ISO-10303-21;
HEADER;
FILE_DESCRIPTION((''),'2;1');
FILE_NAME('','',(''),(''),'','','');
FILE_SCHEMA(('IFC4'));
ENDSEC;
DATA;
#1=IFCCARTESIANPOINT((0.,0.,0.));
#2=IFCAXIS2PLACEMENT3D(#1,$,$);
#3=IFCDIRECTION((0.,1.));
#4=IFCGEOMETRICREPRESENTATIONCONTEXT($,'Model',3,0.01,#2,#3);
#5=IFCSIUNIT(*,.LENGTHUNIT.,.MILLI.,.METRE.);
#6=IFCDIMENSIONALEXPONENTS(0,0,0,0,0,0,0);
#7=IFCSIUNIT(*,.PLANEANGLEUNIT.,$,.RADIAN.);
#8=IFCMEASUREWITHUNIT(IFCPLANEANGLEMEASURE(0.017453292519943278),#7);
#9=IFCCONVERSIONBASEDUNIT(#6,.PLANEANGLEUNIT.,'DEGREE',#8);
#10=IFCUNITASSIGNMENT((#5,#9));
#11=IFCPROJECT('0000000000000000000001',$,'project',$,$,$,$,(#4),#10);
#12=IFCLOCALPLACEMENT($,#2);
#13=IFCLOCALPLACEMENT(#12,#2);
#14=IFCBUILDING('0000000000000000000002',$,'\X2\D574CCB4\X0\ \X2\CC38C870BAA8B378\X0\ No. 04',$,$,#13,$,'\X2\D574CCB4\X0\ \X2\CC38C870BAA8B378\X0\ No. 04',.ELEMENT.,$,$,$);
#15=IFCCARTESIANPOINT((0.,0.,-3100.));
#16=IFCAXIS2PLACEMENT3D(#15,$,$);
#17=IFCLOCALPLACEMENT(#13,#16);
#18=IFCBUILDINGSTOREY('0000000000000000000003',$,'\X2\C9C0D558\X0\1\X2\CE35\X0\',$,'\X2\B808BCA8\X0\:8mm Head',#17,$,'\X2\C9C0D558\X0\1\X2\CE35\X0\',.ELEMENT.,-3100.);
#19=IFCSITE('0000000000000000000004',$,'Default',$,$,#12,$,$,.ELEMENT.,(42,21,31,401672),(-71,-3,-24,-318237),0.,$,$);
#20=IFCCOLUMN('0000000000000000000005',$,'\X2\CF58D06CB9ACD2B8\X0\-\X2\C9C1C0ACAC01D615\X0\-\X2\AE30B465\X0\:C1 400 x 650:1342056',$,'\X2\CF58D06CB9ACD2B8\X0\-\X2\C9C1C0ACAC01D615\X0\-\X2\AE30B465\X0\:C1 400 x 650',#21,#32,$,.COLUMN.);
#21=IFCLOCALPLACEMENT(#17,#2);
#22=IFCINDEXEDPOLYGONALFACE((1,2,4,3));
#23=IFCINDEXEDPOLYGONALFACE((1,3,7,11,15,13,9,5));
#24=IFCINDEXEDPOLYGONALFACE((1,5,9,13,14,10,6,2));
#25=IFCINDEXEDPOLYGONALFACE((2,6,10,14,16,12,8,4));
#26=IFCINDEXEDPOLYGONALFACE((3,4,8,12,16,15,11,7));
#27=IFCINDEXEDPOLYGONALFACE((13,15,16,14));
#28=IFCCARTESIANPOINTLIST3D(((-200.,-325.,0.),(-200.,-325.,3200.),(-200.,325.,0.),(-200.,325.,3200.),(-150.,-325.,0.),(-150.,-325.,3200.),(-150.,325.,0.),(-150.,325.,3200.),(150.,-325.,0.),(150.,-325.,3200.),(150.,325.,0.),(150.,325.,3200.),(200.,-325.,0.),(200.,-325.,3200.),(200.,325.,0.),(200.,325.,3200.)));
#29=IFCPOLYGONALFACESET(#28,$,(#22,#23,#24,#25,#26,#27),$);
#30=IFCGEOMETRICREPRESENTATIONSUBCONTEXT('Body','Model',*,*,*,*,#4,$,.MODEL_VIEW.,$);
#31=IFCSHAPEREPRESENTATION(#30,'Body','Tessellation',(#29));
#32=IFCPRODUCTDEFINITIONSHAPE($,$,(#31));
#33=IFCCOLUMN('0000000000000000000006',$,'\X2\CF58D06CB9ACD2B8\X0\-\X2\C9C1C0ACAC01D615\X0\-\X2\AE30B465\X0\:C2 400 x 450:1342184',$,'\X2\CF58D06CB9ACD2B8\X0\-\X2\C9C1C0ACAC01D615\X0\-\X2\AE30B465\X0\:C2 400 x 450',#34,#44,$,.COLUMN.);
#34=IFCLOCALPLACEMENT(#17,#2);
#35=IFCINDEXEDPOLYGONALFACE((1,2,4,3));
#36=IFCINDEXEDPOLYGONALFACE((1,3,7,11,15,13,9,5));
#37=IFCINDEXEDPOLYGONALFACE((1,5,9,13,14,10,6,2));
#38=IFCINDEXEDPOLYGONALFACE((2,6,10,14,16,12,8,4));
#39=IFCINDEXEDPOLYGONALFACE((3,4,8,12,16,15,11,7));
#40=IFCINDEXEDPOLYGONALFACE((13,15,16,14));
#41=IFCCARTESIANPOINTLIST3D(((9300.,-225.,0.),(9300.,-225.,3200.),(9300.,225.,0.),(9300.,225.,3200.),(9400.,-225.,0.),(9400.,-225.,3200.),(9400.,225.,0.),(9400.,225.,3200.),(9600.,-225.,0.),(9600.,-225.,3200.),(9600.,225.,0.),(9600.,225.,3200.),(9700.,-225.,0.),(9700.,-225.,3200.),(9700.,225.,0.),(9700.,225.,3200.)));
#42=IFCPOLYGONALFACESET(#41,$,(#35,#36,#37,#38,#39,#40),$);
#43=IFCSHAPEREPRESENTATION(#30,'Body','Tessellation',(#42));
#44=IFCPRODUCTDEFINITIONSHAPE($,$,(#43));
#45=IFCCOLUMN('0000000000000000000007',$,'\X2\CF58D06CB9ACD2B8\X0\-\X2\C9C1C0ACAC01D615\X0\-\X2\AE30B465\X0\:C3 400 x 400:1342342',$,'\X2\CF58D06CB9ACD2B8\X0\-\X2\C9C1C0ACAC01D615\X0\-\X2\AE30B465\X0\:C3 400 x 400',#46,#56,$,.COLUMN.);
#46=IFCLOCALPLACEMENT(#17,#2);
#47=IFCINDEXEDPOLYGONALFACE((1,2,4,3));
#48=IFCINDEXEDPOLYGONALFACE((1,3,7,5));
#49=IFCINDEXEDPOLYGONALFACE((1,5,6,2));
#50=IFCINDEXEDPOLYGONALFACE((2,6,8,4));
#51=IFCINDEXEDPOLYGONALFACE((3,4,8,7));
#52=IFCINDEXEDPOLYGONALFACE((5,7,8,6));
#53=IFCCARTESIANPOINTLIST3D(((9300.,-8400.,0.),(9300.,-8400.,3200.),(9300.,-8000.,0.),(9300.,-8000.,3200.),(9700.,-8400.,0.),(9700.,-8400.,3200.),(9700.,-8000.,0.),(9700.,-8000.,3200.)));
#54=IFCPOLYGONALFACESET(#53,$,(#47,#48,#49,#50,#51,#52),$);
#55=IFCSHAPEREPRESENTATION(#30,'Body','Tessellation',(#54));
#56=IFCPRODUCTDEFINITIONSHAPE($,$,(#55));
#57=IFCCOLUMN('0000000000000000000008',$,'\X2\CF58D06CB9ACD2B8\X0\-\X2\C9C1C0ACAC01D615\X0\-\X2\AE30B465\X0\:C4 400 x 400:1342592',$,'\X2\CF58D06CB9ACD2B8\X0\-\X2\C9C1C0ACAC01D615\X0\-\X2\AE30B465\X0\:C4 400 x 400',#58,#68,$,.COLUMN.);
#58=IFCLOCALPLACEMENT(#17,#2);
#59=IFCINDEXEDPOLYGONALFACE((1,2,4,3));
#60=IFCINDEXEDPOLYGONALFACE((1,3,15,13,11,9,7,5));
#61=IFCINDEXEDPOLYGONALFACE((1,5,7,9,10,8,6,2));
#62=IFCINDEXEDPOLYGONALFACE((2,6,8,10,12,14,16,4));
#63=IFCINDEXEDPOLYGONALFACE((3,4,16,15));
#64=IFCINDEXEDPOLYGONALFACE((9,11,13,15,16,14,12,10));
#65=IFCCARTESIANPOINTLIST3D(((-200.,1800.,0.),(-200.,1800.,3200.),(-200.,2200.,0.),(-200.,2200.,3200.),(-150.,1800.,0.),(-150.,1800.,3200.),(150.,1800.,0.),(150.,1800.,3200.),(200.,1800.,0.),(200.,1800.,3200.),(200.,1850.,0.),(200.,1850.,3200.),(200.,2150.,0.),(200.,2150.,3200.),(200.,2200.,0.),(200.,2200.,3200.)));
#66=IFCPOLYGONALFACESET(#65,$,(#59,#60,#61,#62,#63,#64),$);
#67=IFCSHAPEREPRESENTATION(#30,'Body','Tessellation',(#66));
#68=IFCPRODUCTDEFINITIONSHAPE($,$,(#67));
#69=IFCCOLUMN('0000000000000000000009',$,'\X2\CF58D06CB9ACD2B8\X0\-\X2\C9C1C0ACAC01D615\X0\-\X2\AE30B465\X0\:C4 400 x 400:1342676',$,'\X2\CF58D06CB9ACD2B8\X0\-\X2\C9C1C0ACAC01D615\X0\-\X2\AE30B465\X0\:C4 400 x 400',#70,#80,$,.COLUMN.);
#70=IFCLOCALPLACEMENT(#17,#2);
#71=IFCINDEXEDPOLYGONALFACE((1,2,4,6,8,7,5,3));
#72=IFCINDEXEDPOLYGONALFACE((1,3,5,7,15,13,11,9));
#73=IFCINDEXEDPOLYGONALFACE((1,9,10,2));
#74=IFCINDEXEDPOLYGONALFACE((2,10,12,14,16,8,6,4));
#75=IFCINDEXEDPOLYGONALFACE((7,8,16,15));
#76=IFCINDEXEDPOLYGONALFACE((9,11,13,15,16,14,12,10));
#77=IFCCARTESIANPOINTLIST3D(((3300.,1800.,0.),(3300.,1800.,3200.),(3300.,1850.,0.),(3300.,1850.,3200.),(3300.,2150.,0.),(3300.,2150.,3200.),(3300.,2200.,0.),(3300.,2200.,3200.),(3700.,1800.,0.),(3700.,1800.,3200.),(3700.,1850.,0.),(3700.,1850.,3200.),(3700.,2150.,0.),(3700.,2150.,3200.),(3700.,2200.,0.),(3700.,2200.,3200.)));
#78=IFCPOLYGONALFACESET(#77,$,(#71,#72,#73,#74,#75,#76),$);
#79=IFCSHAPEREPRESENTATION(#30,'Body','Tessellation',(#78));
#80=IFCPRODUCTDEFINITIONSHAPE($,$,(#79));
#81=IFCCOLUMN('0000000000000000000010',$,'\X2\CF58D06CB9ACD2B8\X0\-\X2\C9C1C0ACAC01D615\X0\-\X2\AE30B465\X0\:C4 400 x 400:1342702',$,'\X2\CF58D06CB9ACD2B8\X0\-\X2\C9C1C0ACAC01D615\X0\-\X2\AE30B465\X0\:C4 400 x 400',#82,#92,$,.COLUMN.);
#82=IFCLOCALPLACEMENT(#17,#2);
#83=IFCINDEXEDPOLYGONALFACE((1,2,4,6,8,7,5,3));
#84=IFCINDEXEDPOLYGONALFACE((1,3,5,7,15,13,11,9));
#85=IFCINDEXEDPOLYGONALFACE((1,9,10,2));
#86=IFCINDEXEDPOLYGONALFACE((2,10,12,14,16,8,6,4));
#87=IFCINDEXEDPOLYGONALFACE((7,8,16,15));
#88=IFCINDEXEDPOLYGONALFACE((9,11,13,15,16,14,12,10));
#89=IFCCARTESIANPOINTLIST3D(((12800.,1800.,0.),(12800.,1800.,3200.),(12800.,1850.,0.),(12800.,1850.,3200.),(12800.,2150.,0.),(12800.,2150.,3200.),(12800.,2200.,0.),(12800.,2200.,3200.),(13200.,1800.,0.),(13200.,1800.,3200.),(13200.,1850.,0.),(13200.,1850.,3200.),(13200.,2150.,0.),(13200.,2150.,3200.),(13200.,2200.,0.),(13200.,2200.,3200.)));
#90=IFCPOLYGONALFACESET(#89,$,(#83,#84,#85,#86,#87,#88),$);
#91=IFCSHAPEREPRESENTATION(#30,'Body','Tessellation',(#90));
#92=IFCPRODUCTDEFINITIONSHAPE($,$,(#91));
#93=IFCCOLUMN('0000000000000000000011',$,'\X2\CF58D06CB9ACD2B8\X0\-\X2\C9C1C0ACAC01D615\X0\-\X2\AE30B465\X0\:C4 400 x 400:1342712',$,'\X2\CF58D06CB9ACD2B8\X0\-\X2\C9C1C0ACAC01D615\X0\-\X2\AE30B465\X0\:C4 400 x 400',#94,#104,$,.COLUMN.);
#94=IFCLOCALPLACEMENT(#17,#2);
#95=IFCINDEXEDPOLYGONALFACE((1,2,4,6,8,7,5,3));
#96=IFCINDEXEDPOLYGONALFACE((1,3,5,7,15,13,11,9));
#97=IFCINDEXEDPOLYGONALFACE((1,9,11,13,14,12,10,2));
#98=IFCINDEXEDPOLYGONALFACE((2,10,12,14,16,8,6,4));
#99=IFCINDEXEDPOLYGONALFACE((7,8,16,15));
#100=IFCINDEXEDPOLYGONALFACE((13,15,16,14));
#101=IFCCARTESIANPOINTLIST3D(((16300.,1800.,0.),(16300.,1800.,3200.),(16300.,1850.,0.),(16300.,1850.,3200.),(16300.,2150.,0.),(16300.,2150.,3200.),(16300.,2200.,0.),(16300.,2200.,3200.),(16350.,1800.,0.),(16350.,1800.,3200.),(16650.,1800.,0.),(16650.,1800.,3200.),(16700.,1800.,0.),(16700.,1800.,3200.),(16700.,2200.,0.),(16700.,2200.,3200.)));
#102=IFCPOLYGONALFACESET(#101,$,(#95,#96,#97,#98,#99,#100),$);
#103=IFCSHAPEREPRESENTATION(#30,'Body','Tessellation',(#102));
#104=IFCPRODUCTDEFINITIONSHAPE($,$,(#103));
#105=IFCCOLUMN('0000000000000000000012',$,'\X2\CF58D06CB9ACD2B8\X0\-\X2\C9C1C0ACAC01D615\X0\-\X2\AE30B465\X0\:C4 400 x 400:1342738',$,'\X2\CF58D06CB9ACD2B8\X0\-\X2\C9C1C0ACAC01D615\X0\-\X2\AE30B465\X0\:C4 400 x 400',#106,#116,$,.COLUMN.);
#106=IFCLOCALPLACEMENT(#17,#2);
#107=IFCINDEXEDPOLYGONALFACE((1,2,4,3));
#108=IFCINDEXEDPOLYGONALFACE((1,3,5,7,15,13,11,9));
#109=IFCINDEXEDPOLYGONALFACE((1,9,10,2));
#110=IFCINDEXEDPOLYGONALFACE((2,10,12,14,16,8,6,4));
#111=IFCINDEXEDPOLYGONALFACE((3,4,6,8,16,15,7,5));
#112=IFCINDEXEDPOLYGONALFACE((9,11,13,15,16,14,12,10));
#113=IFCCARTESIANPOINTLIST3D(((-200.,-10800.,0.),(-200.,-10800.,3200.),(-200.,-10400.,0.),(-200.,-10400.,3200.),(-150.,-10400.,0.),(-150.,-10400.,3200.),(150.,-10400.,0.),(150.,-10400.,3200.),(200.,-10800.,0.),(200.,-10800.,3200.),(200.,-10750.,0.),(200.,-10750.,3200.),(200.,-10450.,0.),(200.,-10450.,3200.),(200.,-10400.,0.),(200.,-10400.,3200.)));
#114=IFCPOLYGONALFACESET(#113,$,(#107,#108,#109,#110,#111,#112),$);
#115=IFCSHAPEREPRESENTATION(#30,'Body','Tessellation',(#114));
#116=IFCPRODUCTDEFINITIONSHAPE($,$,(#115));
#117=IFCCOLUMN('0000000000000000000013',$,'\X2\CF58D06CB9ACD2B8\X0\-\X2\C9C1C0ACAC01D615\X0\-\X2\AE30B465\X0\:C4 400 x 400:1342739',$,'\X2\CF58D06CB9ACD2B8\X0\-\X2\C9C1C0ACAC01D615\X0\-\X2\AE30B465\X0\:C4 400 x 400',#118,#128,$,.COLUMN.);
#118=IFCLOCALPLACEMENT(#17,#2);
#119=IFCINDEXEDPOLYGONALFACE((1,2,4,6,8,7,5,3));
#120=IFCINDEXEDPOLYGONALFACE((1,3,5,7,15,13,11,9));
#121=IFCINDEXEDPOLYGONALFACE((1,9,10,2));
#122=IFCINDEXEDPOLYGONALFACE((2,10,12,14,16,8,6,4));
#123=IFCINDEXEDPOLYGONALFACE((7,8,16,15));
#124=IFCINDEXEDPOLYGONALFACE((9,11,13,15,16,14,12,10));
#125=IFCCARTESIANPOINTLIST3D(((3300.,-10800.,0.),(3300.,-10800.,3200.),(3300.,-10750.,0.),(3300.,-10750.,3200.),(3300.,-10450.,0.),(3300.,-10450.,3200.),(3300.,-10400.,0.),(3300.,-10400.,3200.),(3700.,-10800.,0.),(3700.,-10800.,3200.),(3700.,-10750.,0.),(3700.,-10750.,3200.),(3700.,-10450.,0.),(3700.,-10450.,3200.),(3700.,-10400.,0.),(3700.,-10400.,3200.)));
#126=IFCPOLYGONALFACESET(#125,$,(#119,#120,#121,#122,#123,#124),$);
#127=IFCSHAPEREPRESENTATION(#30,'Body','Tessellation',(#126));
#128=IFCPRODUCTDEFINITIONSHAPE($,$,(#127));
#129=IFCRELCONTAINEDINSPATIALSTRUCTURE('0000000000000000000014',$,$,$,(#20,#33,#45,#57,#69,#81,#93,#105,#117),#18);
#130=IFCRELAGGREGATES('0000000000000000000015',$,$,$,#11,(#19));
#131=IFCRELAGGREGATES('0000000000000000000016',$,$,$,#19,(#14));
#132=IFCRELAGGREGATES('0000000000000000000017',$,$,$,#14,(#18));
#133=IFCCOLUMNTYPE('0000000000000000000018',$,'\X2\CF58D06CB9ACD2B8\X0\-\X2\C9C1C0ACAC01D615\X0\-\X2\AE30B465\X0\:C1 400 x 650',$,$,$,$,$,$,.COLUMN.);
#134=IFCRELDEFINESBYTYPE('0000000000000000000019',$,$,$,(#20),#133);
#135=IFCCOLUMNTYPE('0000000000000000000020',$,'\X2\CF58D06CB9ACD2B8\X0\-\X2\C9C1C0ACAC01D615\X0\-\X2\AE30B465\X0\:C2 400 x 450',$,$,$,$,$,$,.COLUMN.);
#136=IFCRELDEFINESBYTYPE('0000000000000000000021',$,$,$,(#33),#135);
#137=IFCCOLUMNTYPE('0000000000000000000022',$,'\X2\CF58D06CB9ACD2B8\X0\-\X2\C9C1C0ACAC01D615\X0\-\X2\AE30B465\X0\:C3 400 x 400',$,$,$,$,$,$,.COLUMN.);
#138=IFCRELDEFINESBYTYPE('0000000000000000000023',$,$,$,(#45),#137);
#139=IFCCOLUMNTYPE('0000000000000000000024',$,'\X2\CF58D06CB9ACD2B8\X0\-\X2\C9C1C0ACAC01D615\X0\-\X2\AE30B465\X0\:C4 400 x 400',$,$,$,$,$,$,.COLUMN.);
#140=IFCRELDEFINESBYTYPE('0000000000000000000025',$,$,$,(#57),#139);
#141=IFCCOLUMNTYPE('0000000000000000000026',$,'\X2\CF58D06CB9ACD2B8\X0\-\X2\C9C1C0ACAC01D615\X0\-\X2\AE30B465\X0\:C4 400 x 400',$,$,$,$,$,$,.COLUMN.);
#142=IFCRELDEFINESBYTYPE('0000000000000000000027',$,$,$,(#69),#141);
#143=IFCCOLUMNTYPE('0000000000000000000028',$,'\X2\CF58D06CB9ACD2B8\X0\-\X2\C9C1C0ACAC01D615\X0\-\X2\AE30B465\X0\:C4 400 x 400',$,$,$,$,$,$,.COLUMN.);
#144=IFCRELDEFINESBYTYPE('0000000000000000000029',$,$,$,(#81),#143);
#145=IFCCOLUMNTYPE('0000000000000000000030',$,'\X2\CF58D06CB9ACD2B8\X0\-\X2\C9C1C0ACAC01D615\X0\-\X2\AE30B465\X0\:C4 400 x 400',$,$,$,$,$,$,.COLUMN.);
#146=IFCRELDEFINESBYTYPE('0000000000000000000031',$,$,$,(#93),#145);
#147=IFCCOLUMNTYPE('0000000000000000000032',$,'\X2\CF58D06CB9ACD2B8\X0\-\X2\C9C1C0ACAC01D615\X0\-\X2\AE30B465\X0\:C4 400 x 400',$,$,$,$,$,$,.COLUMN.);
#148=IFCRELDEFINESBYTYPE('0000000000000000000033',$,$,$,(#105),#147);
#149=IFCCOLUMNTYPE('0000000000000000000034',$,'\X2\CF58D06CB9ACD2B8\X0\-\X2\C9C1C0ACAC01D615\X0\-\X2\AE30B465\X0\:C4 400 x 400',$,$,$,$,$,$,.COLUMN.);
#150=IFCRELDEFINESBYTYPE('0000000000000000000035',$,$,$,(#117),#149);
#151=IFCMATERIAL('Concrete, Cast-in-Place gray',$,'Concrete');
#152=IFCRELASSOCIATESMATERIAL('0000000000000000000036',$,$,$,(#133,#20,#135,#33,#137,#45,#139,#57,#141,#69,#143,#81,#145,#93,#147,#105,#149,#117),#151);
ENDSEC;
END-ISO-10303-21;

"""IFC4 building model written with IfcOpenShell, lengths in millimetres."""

from ifc_helpers import new_model, entity, si_unit, converted_unit, direction, frame, origin, place, context, subcontext, project, spatial, indexed_curve, outline, extrude, source, transform, mapped, material, type_object, type_shapes, element, save


model = new_model("IFC4")

# Units and contexts
model_context = context("Model", 3, precision=0.01, world=origin(), true_north=direction((0.0, 1.0)))
body_context = subcontext(model_context, "Body", "Model", "MODEL_VIEW")
ifc_project = project(units=[si_unit("LENGTHUNIT", "METRE", prefix="MILLI"), converted_unit("PLANEANGLEUNIT", "DEGREE", entity("IfcPlaneAngleMeasure", 0.017453292519943278), si_unit("PLANEANGLEUNIT", "RADIAN"), dimensions=[0, 0, 0, 0, 0, 0, 0])], contexts=[model_context])

# Site, building, storey
site_placement = place(None, origin())
site = spatial("IfcSite", under=ifc_project, at=site_placement, Name="Default", CompositionType="ELEMENT", RefLatitude=(42, 21, 31, 401672), RefLongitude=(-71, -3, -24, -318237), RefElevation=0.0)
building_placement = place(site_placement, origin())
building = spatial("IfcBuilding", under=site, at=building_placement, Name="해체 참조모델 No. 04", LongName="해체 참조모델 No. 04", CompositionType="ELEMENT")
storey_placement = place(building_placement, frame((0.0, 0.0, -3100.0)))
storey = spatial("IfcBuildingStorey", under=building, at=storey_placement, Name="지하1층", ObjectType="레벨:8mm Head", LongName="지하1층", CompositionType="ELEMENT", Elevation=-3100.0)

# Columns
ifc_material = material(Name="Concrete, Cast-in-Place gray", Category="Concrete")
column_type_1 = type_object("IfcColumnType", Name="콘크리트-직사각형-기둥:C1 400 x 650", PredefinedType="COLUMN", material=ifc_material)
shared_shape_1 = source(origin(), body_context, "Body", "SweptSolid", [
    extrude(outline(indexed_curve([(-200.0, -325.0), (-150.0, -325.0), (150.0, -325.0), (200.0, -325.0), (200.0, 325.0), (150.0, 325.0), (-150.0, 325.0), (-200.0, 325.0), (-200.0, -325.0)], self_intersect=False)), frame((0.0, 0.0, -3100.0), z_axis=(0.0, 0.0, 1.0), x_axis=(-1.0, 0.0, 0.0)), (0.0, 0.0, 1.0), 3200.0),
])
type_shapes(column_type_1, [shared_shape_1])
column_1_placement = place(storey_placement, frame((0.0, 0.0, 3100.0)))
element("IfcColumn", 1, at=column_1_placement, inside=storey, type_object=column_type_1, material=ifc_material, Name="콘크리트-직사각형-기둥:C1 400 x 650:1342056", ObjectType="콘크리트-직사각형-기둥:C1 400 x 650", PredefinedType="COLUMN", context=body_context, shape_type="MappedRepresentation", body=[
    mapped(shared_shape_1, transform((0.0, 0.0, 0.0), scale=1.0)),
])
column_type_2 = type_object("IfcColumnType", Name="콘크리트-직사각형-기둥:C2 400 x 450", PredefinedType="COLUMN", material=ifc_material)
shared_shape_2 = source(origin(), body_context, "Body", "SweptSolid", [
    extrude(outline(indexed_curve([(-200.0, -225.0), (-100.0, -225.0), (100.0, -225.0), (200.0, -225.0), (200.0, 225.0), (100.0, 225.0), (-100.0, 225.0), (-200.0, 225.0), (-200.0, -225.0)], self_intersect=False)), frame((9500.0, 0.0, -3100.0), z_axis=(0.0, 0.0, 1.0), x_axis=(-1.0, 0.0, 0.0)), (0.0, 0.0, 1.0), 3200.0),
])
type_shapes(column_type_2, [shared_shape_2])
column_2_placement = place(storey_placement, frame((0.0, 0.0, 3100.0)))
element("IfcColumn", 2, at=column_2_placement, inside=storey, type_object=column_type_2, material=ifc_material, Name="콘크리트-직사각형-기둥:C2 400 x 450:1342184", ObjectType="콘크리트-직사각형-기둥:C2 400 x 450", PredefinedType="COLUMN", context=body_context, shape_type="MappedRepresentation", body=[
    mapped(shared_shape_2, transform((0.0, 0.0, 0.0), scale=1.0)),
])
column_type_3 = type_object("IfcColumnType", Name="콘크리트-직사각형-기둥:C3 400 x 400", PredefinedType="COLUMN", material=ifc_material)
shared_shape_3 = source(origin(), body_context, "Body", "SweptSolid", [
    extrude(outline(indexed_curve([(-200.0, -200.0), (200.0, -200.0), (200.0, 200.0), (-200.0, 200.0), (-200.0, -200.0)], self_intersect=False)), frame((9500.0, -8200.0, -3100.0), z_axis=(0.0, 0.0, 1.0), x_axis=(-1.0, 0.0, 0.0)), (0.0, 0.0, 1.0), 3200.0),
])
type_shapes(column_type_3, [shared_shape_3])
column_3_placement = place(storey_placement, frame((0.0, 0.0, 3100.0)))
element("IfcColumn", 3, at=column_3_placement, inside=storey, type_object=column_type_3, material=ifc_material, Name="콘크리트-직사각형-기둥:C3 400 x 400:1342342", ObjectType="콘크리트-직사각형-기둥:C3 400 x 400", PredefinedType="COLUMN", context=body_context, shape_type="MappedRepresentation", body=[
    mapped(shared_shape_3, transform((0.0, 0.0, 0.0), scale=1.0)),
])
column_type_4 = type_object("IfcColumnType", Name="콘크리트-직사각형-기둥:C4 400 x 400", PredefinedType="COLUMN", material=ifc_material)
shared_shape_4 = source(origin(), body_context, "Body", "SweptSolid", [
    extrude(outline(indexed_curve([(-150.0, -250.0), (250.0, -250.0), (250.0, 150.0), (200.0, 150.0), (-100.0, 150.0), (-150.0, 150.0), (-150.0, 100.0), (-150.0, -200.0), (-150.0, -250.0)], self_intersect=False)), frame((50.0, 1950.0, -3100.0), z_axis=(0.0, 0.0, 1.0), x_axis=(-1.0, 0.0, 0.0)), (0.0, 0.0, 1.0), 3200.0),
])
type_shapes(column_type_4, [shared_shape_4])
column_4_placement = place(storey_placement, frame((0.0, 0.0, 3100.0)))
element("IfcColumn", 4, at=column_4_placement, inside=storey, type_object=column_type_4, material=ifc_material, Name="콘크리트-직사각형-기둥:C4 400 x 400:1342592", ObjectType="콘크리트-직사각형-기둥:C4 400 x 400", PredefinedType="COLUMN", context=body_context, shape_type="MappedRepresentation", body=[
    mapped(shared_shape_4, transform((0.0, 0.0, 0.0), scale=1.0)),
])
column_type_5 = type_object("IfcColumnType", Name="콘크리트-직사각형-기둥:C4 400 x 400", PredefinedType="COLUMN", material=ifc_material)
shared_shape_5 = source(origin(), body_context, "Body", "SweptSolid", [
    extrude(outline(indexed_curve([(-200.0, -200.0), (200.0, -200.0), (200.0, -150.0), (200.0, 150.0), (200.0, 200.0), (-200.0, 200.0), (-200.0, 150.0), (-200.0, -150.0), (-200.0, -200.0)], self_intersect=False)), frame((3500.0, 2000.0, -3100.0), z_axis=(0.0, 0.0, 1.0), x_axis=(-1.0, 0.0, 0.0)), (0.0, 0.0, 1.0), 3200.0),
])
type_shapes(column_type_5, [shared_shape_5])
column_5_placement = place(storey_placement, frame((0.0, 0.0, 3100.0)))
element("IfcColumn", 5, at=column_5_placement, inside=storey, type_object=column_type_5, material=ifc_material, Name="콘크리트-직사각형-기둥:C4 400 x 400:1342676", ObjectType="콘크리트-직사각형-기둥:C4 400 x 400", PredefinedType="COLUMN", context=body_context, shape_type="MappedRepresentation", body=[
    mapped(shared_shape_5, transform((0.0, 0.0, 0.0), scale=1.0)),
])
column_type_6 = type_object("IfcColumnType", Name="콘크리트-직사각형-기둥:C4 400 x 400", PredefinedType="COLUMN", material=ifc_material)
shared_shape_6 = source(origin(), body_context, "Body", "SweptSolid", [
    extrude(outline(indexed_curve([(-200.0, -200.0), (200.0, -200.0), (200.0, -150.0), (200.0, 150.0), (200.0, 200.0), (-200.0, 200.0), (-200.0, 150.0), (-200.0, -150.0), (-200.0, -200.0)], self_intersect=False)), frame((13000.0, 2000.0, -3100.0), z_axis=(0.0, 0.0, 1.0), x_axis=(-1.0, 0.0, 0.0)), (0.0, 0.0, 1.0), 3200.0),
])
type_shapes(column_type_6, [shared_shape_6])
column_6_placement = place(storey_placement, frame((0.0, 0.0, 3100.0)))
element("IfcColumn", 6, at=column_6_placement, inside=storey, type_object=column_type_6, material=ifc_material, Name="콘크리트-직사각형-기둥:C4 400 x 400:1342702", ObjectType="콘크리트-직사각형-기둥:C4 400 x 400", PredefinedType="COLUMN", context=body_context, shape_type="MappedRepresentation", body=[
    mapped(shared_shape_6, transform((0.0, 0.0, 0.0), scale=1.0)),
])
column_type_7 = type_object("IfcColumnType", Name="콘크리트-직사각형-기둥:C4 400 x 400", PredefinedType="COLUMN", material=ifc_material)
shared_shape_7 = source(origin(), body_context, "Body", "SweptSolid", [
    extrude(outline(indexed_curve([(-250.0, -250.0), (150.0, -250.0), (150.0, -200.0), (150.0, 100.0), (150.0, 150.0), (100.0, 150.0), (-200.0, 150.0), (-250.0, 150.0), (-250.0, -250.0)], self_intersect=False)), frame((16450.0, 1950.0, -3100.0), z_axis=(0.0, 0.0, 1.0), x_axis=(-1.0, 0.0, 0.0)), (0.0, 0.0, 1.0), 3200.0),
])
type_shapes(column_type_7, [shared_shape_7])
column_7_placement = place(storey_placement, frame((0.0, 0.0, 3100.0)))
element("IfcColumn", 7, at=column_7_placement, inside=storey, type_object=column_type_7, material=ifc_material, Name="콘크리트-직사각형-기둥:C4 400 x 400:1342712", ObjectType="콘크리트-직사각형-기둥:C4 400 x 400", PredefinedType="COLUMN", context=body_context, shape_type="MappedRepresentation", body=[
    mapped(shared_shape_7, transform((0.0, 0.0, 0.0), scale=1.0)),
])
column_type_8 = type_object("IfcColumnType", Name="콘크리트-직사각형-기둥:C4 400 x 400", PredefinedType="COLUMN", material=ifc_material)
shared_shape_8 = source(origin(), body_context, "Body", "SweptSolid", [
    extrude(outline(indexed_curve([(-150.0, -150.0), (-100.0, -150.0), (200.0, -150.0), (250.0, -150.0), (250.0, 250.0), (-150.0, 250.0), (-150.0, 200.0), (-150.0, -100.0), (-150.0, -150.0)], self_intersect=False)), frame((50.0, -10550.0, -3100.0), z_axis=(0.0, 0.0, 1.0), x_axis=(-1.0, 0.0, 0.0)), (0.0, 0.0, 1.0), 3200.0),
])
type_shapes(column_type_8, [shared_shape_8])
column_8_placement = place(storey_placement, frame((0.0, 0.0, 3100.0)))
element("IfcColumn", 8, at=column_8_placement, inside=storey, type_object=column_type_8, material=ifc_material, Name="콘크리트-직사각형-기둥:C4 400 x 400:1342738", ObjectType="콘크리트-직사각형-기둥:C4 400 x 400", PredefinedType="COLUMN", context=body_context, shape_type="MappedRepresentation", body=[
    mapped(shared_shape_8, transform((0.0, 0.0, 0.0), scale=1.0)),
])
column_type_9 = type_object("IfcColumnType", Name="콘크리트-직사각형-기둥:C4 400 x 400", PredefinedType="COLUMN", material=ifc_material)
shared_shape_9 = source(origin(), body_context, "Body", "SweptSolid", [
    extrude(outline(indexed_curve([(-200.0, -200.0), (200.0, -200.0), (200.0, -150.0), (200.0, 150.0), (200.0, 200.0), (-200.0, 200.0), (-200.0, 150.0), (-200.0, -150.0), (-200.0, -200.0)], self_intersect=False)), frame((3500.0, -10600.0, -3100.0), z_axis=(0.0, 0.0, 1.0), x_axis=(-1.0, 0.0, 0.0)), (0.0, 0.0, 1.0), 3200.0),
])
type_shapes(column_type_9, [shared_shape_9])
column_9_placement = place(storey_placement, frame((0.0, 0.0, 3100.0)))
element("IfcColumn", 9, at=column_9_placement, inside=storey, type_object=column_type_9, material=ifc_material, Name="콘크리트-직사각형-기둥:C4 400 x 400:1342739", ObjectType="콘크리트-직사각형-기둥:C4 400 x 400", PredefinedType="COLUMN", context=body_context, shape_type="MappedRepresentation", body=[
    mapped(shared_shape_9, transform((0.0, 0.0, 0.0), scale=1.0)),
])

save(model, "model.ifc")
